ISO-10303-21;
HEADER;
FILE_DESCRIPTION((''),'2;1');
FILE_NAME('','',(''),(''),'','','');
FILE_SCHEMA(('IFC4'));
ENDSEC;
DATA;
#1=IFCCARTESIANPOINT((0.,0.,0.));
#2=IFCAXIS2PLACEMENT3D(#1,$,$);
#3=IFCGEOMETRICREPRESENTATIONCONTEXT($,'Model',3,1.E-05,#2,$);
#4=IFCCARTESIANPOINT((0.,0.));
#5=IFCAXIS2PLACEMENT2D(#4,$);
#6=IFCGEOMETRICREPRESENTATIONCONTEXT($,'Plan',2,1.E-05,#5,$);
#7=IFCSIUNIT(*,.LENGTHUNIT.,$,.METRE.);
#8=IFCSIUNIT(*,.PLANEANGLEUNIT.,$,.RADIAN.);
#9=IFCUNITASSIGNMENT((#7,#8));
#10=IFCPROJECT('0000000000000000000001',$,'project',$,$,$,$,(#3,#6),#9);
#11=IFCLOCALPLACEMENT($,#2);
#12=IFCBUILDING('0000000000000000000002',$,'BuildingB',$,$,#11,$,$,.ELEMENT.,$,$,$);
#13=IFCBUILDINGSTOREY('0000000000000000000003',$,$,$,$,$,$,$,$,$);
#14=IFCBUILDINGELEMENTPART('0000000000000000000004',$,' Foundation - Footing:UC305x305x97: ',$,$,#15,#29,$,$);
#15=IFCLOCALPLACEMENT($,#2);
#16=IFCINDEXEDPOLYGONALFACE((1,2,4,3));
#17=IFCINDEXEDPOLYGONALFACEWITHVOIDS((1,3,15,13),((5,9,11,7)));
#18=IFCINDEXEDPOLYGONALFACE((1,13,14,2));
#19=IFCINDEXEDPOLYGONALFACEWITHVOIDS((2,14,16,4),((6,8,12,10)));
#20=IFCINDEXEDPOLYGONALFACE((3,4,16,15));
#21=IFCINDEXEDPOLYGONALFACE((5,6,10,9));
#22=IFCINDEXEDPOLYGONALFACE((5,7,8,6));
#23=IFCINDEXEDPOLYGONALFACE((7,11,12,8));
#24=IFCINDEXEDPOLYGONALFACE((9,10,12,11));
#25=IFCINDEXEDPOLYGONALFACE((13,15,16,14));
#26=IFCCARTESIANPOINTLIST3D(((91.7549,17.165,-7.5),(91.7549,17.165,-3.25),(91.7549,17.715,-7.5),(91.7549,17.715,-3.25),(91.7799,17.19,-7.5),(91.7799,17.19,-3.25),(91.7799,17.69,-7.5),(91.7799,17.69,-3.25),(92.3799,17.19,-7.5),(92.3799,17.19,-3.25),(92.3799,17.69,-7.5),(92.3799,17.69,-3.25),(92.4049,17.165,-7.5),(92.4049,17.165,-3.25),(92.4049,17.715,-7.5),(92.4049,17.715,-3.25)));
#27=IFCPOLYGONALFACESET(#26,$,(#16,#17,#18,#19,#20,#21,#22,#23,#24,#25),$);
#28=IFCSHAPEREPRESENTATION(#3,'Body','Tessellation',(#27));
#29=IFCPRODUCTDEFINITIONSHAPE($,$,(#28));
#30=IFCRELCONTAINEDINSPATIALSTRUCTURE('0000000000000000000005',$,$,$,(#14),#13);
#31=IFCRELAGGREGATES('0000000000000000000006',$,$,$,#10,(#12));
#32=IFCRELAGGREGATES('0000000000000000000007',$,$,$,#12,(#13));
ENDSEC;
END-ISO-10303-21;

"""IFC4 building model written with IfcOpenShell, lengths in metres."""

from ifc_helpers import new_model, si_unit, origin, origin_2d, place, context, project, spatial, polyline, outline, extrude, element, save


model = new_model("IFC4")

# Units and contexts
model_context = context("Model", 3, precision=1e-05, world=origin())
plan_context = context("Plan", 2, precision=1e-05, world=origin_2d())
ifc_project = project(units=[si_unit("LENGTHUNIT", "METRE"), si_unit("PLANEANGLEUNIT", "RADIAN")], contexts=[model_context, plan_context])

# Building, storey
building_placement = place(None, origin())
building = spatial("IfcBuilding", under=ifc_project, at=building_placement, Name="BuildingB", CompositionType="ELEMENT")
storey = spatial("IfcBuildingStorey", under=building)

# Building element part, opening
building_element_part_1 = element("IfcBuildingElementPart", 1, inside=storey, Name=" Foundation - Footing:UC305x305x97: ", context=model_context, shape_type="SweptSolid", body=[
    extrude(outline(polyline([(92.4049, 17.715, -7.5), (91.7549, 17.715, -7.5), (91.7549, 17.165, -7.5), (92.4049, 17.165, -7.5), (92.4049, 17.715, -7.5)])), None, (0.0, 0.0, 1.0), 4.25),
])
element("IfcOpeningElement", 2, inside=storey, cuts=building_element_part_1, context=model_context, shape_type="SweptSolid", body=[
    extrude(outline(polyline([(92.3799, 17.69, -7.5), (91.7799, 17.69, -7.5), (91.7799, 17.19, -7.5), (92.3799, 17.19, -7.5), (92.3799, 17.69, -7.5)])), None, (0.0, 0.0, 1.0), 4.25),
])

save(model, "model.ifc")
